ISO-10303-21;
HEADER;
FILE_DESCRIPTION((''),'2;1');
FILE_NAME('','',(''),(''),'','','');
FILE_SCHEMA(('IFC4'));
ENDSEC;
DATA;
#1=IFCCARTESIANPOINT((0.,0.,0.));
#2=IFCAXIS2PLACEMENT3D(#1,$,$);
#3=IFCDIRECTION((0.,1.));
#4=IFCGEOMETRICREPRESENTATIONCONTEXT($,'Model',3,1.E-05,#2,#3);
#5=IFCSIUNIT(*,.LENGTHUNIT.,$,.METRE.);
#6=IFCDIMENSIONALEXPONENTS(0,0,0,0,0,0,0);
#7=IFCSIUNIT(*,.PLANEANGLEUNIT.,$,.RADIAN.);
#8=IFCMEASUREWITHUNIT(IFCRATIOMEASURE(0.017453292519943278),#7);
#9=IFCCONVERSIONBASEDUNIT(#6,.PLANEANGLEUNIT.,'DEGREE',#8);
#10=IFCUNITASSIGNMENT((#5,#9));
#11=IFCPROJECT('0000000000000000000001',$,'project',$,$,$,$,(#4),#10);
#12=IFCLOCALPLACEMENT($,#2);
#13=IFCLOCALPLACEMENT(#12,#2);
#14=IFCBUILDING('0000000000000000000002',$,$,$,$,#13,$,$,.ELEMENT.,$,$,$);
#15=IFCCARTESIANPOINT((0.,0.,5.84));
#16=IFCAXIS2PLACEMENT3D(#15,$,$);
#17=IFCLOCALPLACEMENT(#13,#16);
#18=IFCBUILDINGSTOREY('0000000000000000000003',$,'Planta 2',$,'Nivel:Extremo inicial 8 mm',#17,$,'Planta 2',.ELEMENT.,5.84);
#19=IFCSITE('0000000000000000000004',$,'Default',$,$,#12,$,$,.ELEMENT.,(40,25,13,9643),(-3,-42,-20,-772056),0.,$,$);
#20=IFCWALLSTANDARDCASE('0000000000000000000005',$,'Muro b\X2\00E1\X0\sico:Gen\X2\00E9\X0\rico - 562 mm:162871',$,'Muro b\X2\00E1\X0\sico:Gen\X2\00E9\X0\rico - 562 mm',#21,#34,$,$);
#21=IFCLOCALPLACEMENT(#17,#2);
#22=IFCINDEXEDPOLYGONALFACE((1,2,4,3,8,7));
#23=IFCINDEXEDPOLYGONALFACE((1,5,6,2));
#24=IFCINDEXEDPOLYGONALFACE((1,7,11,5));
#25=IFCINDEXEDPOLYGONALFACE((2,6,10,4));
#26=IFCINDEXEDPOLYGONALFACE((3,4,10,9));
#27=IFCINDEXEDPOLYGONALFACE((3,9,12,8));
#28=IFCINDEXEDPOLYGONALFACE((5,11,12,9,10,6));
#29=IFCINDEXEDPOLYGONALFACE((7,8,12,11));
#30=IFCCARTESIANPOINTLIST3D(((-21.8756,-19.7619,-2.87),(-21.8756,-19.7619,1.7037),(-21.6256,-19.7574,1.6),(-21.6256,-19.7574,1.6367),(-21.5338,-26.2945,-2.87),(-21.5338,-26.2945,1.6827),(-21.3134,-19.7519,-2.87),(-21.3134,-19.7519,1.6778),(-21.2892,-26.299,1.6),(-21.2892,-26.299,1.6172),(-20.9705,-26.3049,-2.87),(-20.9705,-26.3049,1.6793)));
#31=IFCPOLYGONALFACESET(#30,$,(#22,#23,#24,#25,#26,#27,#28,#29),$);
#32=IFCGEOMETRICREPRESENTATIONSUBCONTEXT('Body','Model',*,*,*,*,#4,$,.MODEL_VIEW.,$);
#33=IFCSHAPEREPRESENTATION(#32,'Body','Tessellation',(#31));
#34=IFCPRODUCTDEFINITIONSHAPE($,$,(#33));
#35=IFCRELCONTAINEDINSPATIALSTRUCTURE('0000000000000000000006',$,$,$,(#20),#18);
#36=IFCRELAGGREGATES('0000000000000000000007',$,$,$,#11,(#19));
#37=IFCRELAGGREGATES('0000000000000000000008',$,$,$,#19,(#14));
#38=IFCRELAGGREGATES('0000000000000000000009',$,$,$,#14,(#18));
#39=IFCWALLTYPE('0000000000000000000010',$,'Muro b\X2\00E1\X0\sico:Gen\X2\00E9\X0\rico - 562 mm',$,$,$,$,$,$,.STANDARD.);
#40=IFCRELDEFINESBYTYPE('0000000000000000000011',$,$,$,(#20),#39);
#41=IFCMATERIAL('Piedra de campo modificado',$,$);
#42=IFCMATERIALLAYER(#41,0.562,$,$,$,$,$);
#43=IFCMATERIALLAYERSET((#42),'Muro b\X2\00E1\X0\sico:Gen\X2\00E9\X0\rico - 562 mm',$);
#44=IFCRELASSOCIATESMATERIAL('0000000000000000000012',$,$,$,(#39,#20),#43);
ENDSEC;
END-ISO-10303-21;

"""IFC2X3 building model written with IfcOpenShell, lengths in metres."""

from ifc_helpers import new_model, entity, si_unit, converted_unit, direction, frame, origin, place, context, subcontext, project, spatial, polyline, outline, extrude, clip, bounded_halfspace, material, layer, layer_set, layer_usage, type_object, element, save


model = new_model("IFC2X3")

# Units and contexts
model_context = context("Model", 3, precision=1e-05, world=origin(), true_north=direction((0.0, 1.0)))
body_context = subcontext(model_context, "Body", "Model", "MODEL_VIEW")
ifc_project = project(units=[si_unit("LENGTHUNIT", "METRE"), converted_unit("PLANEANGLEUNIT", "DEGREE", entity("IfcRatioMeasure", 0.017453292519943278), si_unit("PLANEANGLEUNIT", "RADIAN"), dimensions=[0, 0, 0, 0, 0, 0, 0])], contexts=[model_context])

# Site, building, storey
site_placement = place(None, origin())
site = spatial("IfcSite", under=ifc_project, at=site_placement, Name="Default", CompositionType="ELEMENT", RefLatitude=(40, 25, 13, 9643), RefLongitude=(-3, -42, -20, -772056), RefElevation=0.0)
building_placement = place(site_placement, origin())
building = spatial("IfcBuilding", under=site, at=building_placement, CompositionType="ELEMENT")
storey_placement = place(building_placement, frame((0.0, 0.0, 5.84)))
storey = spatial("IfcBuildingStorey", under=building, at=storey_placement, Name="Planta 2", ObjectType="Nivel:Extremo inicial 8 mm", LongName="Planta 2", CompositionType="ELEMENT", Elevation=5.84)

# Wall
ifc_material_1 = material(Name="Piedra de campo modificado")
ifc_layer_1 = layer(ifc_material_1, 0.562)
ifc_layer_set_1 = layer_set([ifc_layer_1], Name="Muro básico:Genérico - 562 mm")
ifc_layer_usage_1 = layer_usage(ifc_layer_set_1, "AXIS2", "NEGATIVE", 0.281)
wall_type = type_object("IfcWallType", Name="Muro básico:Genérico - 562 mm", PredefinedType="STANDARD", material=ifc_layer_set_1)
wall_placement = place(storey_placement, frame((-21.595, -19.7472, -2.87), z_axis=(0.0, 0.0, 1.0), x_axis=(0.052264, -0.998633, 0.0)))
element("IfcWallStandardCase", 1, at=wall_placement, inside=storey, type_object=wall_type, material=ifc_layer_usage_1, Name="Muro básico:Genérico - 562 mm:162871", ObjectType="Muro básico:Genérico - 562 mm", context=body_context, shape_type="Clipping", body=[
    clip(clip(extrude(outline(polyline([(6.5416, -0.281), (6.5814, 0.281), (0.0194, 0.281), (0.0, -0.281), (6.5416, -0.281)])), origin(), (0.0, 0.0, 1.0), 4.5737), bounded_halfspace(frame((6.5814, 0.281, 4.5493), z_axis=(-0.000218, -0.241922, 0.970296), x_axis=(1.0, -0.000901, 0.0)), False, frame((6.5814, 0.281, 4.5493)), polyline([(0.0, 0.0), (-6.562, 0.0), (-6.5728, -0.3121), (-0.0225, -0.318), (0.0, 0.0)]))), bounded_halfspace(frame((0.0, -0.281, 4.5737), z_axis=(0.003108, 0.2588, 0.965926), x_axis=(-0.999928, 0.012008, 0.0)), False, frame((0.0, -0.281, 4.5737)), polyline([(0.0, 0.0), (6.5416, 0.0), (6.5589, 0.244), (0.0086, 0.2499), (0.0, 0.0)]))),
])

save(model, "model.ifc")
